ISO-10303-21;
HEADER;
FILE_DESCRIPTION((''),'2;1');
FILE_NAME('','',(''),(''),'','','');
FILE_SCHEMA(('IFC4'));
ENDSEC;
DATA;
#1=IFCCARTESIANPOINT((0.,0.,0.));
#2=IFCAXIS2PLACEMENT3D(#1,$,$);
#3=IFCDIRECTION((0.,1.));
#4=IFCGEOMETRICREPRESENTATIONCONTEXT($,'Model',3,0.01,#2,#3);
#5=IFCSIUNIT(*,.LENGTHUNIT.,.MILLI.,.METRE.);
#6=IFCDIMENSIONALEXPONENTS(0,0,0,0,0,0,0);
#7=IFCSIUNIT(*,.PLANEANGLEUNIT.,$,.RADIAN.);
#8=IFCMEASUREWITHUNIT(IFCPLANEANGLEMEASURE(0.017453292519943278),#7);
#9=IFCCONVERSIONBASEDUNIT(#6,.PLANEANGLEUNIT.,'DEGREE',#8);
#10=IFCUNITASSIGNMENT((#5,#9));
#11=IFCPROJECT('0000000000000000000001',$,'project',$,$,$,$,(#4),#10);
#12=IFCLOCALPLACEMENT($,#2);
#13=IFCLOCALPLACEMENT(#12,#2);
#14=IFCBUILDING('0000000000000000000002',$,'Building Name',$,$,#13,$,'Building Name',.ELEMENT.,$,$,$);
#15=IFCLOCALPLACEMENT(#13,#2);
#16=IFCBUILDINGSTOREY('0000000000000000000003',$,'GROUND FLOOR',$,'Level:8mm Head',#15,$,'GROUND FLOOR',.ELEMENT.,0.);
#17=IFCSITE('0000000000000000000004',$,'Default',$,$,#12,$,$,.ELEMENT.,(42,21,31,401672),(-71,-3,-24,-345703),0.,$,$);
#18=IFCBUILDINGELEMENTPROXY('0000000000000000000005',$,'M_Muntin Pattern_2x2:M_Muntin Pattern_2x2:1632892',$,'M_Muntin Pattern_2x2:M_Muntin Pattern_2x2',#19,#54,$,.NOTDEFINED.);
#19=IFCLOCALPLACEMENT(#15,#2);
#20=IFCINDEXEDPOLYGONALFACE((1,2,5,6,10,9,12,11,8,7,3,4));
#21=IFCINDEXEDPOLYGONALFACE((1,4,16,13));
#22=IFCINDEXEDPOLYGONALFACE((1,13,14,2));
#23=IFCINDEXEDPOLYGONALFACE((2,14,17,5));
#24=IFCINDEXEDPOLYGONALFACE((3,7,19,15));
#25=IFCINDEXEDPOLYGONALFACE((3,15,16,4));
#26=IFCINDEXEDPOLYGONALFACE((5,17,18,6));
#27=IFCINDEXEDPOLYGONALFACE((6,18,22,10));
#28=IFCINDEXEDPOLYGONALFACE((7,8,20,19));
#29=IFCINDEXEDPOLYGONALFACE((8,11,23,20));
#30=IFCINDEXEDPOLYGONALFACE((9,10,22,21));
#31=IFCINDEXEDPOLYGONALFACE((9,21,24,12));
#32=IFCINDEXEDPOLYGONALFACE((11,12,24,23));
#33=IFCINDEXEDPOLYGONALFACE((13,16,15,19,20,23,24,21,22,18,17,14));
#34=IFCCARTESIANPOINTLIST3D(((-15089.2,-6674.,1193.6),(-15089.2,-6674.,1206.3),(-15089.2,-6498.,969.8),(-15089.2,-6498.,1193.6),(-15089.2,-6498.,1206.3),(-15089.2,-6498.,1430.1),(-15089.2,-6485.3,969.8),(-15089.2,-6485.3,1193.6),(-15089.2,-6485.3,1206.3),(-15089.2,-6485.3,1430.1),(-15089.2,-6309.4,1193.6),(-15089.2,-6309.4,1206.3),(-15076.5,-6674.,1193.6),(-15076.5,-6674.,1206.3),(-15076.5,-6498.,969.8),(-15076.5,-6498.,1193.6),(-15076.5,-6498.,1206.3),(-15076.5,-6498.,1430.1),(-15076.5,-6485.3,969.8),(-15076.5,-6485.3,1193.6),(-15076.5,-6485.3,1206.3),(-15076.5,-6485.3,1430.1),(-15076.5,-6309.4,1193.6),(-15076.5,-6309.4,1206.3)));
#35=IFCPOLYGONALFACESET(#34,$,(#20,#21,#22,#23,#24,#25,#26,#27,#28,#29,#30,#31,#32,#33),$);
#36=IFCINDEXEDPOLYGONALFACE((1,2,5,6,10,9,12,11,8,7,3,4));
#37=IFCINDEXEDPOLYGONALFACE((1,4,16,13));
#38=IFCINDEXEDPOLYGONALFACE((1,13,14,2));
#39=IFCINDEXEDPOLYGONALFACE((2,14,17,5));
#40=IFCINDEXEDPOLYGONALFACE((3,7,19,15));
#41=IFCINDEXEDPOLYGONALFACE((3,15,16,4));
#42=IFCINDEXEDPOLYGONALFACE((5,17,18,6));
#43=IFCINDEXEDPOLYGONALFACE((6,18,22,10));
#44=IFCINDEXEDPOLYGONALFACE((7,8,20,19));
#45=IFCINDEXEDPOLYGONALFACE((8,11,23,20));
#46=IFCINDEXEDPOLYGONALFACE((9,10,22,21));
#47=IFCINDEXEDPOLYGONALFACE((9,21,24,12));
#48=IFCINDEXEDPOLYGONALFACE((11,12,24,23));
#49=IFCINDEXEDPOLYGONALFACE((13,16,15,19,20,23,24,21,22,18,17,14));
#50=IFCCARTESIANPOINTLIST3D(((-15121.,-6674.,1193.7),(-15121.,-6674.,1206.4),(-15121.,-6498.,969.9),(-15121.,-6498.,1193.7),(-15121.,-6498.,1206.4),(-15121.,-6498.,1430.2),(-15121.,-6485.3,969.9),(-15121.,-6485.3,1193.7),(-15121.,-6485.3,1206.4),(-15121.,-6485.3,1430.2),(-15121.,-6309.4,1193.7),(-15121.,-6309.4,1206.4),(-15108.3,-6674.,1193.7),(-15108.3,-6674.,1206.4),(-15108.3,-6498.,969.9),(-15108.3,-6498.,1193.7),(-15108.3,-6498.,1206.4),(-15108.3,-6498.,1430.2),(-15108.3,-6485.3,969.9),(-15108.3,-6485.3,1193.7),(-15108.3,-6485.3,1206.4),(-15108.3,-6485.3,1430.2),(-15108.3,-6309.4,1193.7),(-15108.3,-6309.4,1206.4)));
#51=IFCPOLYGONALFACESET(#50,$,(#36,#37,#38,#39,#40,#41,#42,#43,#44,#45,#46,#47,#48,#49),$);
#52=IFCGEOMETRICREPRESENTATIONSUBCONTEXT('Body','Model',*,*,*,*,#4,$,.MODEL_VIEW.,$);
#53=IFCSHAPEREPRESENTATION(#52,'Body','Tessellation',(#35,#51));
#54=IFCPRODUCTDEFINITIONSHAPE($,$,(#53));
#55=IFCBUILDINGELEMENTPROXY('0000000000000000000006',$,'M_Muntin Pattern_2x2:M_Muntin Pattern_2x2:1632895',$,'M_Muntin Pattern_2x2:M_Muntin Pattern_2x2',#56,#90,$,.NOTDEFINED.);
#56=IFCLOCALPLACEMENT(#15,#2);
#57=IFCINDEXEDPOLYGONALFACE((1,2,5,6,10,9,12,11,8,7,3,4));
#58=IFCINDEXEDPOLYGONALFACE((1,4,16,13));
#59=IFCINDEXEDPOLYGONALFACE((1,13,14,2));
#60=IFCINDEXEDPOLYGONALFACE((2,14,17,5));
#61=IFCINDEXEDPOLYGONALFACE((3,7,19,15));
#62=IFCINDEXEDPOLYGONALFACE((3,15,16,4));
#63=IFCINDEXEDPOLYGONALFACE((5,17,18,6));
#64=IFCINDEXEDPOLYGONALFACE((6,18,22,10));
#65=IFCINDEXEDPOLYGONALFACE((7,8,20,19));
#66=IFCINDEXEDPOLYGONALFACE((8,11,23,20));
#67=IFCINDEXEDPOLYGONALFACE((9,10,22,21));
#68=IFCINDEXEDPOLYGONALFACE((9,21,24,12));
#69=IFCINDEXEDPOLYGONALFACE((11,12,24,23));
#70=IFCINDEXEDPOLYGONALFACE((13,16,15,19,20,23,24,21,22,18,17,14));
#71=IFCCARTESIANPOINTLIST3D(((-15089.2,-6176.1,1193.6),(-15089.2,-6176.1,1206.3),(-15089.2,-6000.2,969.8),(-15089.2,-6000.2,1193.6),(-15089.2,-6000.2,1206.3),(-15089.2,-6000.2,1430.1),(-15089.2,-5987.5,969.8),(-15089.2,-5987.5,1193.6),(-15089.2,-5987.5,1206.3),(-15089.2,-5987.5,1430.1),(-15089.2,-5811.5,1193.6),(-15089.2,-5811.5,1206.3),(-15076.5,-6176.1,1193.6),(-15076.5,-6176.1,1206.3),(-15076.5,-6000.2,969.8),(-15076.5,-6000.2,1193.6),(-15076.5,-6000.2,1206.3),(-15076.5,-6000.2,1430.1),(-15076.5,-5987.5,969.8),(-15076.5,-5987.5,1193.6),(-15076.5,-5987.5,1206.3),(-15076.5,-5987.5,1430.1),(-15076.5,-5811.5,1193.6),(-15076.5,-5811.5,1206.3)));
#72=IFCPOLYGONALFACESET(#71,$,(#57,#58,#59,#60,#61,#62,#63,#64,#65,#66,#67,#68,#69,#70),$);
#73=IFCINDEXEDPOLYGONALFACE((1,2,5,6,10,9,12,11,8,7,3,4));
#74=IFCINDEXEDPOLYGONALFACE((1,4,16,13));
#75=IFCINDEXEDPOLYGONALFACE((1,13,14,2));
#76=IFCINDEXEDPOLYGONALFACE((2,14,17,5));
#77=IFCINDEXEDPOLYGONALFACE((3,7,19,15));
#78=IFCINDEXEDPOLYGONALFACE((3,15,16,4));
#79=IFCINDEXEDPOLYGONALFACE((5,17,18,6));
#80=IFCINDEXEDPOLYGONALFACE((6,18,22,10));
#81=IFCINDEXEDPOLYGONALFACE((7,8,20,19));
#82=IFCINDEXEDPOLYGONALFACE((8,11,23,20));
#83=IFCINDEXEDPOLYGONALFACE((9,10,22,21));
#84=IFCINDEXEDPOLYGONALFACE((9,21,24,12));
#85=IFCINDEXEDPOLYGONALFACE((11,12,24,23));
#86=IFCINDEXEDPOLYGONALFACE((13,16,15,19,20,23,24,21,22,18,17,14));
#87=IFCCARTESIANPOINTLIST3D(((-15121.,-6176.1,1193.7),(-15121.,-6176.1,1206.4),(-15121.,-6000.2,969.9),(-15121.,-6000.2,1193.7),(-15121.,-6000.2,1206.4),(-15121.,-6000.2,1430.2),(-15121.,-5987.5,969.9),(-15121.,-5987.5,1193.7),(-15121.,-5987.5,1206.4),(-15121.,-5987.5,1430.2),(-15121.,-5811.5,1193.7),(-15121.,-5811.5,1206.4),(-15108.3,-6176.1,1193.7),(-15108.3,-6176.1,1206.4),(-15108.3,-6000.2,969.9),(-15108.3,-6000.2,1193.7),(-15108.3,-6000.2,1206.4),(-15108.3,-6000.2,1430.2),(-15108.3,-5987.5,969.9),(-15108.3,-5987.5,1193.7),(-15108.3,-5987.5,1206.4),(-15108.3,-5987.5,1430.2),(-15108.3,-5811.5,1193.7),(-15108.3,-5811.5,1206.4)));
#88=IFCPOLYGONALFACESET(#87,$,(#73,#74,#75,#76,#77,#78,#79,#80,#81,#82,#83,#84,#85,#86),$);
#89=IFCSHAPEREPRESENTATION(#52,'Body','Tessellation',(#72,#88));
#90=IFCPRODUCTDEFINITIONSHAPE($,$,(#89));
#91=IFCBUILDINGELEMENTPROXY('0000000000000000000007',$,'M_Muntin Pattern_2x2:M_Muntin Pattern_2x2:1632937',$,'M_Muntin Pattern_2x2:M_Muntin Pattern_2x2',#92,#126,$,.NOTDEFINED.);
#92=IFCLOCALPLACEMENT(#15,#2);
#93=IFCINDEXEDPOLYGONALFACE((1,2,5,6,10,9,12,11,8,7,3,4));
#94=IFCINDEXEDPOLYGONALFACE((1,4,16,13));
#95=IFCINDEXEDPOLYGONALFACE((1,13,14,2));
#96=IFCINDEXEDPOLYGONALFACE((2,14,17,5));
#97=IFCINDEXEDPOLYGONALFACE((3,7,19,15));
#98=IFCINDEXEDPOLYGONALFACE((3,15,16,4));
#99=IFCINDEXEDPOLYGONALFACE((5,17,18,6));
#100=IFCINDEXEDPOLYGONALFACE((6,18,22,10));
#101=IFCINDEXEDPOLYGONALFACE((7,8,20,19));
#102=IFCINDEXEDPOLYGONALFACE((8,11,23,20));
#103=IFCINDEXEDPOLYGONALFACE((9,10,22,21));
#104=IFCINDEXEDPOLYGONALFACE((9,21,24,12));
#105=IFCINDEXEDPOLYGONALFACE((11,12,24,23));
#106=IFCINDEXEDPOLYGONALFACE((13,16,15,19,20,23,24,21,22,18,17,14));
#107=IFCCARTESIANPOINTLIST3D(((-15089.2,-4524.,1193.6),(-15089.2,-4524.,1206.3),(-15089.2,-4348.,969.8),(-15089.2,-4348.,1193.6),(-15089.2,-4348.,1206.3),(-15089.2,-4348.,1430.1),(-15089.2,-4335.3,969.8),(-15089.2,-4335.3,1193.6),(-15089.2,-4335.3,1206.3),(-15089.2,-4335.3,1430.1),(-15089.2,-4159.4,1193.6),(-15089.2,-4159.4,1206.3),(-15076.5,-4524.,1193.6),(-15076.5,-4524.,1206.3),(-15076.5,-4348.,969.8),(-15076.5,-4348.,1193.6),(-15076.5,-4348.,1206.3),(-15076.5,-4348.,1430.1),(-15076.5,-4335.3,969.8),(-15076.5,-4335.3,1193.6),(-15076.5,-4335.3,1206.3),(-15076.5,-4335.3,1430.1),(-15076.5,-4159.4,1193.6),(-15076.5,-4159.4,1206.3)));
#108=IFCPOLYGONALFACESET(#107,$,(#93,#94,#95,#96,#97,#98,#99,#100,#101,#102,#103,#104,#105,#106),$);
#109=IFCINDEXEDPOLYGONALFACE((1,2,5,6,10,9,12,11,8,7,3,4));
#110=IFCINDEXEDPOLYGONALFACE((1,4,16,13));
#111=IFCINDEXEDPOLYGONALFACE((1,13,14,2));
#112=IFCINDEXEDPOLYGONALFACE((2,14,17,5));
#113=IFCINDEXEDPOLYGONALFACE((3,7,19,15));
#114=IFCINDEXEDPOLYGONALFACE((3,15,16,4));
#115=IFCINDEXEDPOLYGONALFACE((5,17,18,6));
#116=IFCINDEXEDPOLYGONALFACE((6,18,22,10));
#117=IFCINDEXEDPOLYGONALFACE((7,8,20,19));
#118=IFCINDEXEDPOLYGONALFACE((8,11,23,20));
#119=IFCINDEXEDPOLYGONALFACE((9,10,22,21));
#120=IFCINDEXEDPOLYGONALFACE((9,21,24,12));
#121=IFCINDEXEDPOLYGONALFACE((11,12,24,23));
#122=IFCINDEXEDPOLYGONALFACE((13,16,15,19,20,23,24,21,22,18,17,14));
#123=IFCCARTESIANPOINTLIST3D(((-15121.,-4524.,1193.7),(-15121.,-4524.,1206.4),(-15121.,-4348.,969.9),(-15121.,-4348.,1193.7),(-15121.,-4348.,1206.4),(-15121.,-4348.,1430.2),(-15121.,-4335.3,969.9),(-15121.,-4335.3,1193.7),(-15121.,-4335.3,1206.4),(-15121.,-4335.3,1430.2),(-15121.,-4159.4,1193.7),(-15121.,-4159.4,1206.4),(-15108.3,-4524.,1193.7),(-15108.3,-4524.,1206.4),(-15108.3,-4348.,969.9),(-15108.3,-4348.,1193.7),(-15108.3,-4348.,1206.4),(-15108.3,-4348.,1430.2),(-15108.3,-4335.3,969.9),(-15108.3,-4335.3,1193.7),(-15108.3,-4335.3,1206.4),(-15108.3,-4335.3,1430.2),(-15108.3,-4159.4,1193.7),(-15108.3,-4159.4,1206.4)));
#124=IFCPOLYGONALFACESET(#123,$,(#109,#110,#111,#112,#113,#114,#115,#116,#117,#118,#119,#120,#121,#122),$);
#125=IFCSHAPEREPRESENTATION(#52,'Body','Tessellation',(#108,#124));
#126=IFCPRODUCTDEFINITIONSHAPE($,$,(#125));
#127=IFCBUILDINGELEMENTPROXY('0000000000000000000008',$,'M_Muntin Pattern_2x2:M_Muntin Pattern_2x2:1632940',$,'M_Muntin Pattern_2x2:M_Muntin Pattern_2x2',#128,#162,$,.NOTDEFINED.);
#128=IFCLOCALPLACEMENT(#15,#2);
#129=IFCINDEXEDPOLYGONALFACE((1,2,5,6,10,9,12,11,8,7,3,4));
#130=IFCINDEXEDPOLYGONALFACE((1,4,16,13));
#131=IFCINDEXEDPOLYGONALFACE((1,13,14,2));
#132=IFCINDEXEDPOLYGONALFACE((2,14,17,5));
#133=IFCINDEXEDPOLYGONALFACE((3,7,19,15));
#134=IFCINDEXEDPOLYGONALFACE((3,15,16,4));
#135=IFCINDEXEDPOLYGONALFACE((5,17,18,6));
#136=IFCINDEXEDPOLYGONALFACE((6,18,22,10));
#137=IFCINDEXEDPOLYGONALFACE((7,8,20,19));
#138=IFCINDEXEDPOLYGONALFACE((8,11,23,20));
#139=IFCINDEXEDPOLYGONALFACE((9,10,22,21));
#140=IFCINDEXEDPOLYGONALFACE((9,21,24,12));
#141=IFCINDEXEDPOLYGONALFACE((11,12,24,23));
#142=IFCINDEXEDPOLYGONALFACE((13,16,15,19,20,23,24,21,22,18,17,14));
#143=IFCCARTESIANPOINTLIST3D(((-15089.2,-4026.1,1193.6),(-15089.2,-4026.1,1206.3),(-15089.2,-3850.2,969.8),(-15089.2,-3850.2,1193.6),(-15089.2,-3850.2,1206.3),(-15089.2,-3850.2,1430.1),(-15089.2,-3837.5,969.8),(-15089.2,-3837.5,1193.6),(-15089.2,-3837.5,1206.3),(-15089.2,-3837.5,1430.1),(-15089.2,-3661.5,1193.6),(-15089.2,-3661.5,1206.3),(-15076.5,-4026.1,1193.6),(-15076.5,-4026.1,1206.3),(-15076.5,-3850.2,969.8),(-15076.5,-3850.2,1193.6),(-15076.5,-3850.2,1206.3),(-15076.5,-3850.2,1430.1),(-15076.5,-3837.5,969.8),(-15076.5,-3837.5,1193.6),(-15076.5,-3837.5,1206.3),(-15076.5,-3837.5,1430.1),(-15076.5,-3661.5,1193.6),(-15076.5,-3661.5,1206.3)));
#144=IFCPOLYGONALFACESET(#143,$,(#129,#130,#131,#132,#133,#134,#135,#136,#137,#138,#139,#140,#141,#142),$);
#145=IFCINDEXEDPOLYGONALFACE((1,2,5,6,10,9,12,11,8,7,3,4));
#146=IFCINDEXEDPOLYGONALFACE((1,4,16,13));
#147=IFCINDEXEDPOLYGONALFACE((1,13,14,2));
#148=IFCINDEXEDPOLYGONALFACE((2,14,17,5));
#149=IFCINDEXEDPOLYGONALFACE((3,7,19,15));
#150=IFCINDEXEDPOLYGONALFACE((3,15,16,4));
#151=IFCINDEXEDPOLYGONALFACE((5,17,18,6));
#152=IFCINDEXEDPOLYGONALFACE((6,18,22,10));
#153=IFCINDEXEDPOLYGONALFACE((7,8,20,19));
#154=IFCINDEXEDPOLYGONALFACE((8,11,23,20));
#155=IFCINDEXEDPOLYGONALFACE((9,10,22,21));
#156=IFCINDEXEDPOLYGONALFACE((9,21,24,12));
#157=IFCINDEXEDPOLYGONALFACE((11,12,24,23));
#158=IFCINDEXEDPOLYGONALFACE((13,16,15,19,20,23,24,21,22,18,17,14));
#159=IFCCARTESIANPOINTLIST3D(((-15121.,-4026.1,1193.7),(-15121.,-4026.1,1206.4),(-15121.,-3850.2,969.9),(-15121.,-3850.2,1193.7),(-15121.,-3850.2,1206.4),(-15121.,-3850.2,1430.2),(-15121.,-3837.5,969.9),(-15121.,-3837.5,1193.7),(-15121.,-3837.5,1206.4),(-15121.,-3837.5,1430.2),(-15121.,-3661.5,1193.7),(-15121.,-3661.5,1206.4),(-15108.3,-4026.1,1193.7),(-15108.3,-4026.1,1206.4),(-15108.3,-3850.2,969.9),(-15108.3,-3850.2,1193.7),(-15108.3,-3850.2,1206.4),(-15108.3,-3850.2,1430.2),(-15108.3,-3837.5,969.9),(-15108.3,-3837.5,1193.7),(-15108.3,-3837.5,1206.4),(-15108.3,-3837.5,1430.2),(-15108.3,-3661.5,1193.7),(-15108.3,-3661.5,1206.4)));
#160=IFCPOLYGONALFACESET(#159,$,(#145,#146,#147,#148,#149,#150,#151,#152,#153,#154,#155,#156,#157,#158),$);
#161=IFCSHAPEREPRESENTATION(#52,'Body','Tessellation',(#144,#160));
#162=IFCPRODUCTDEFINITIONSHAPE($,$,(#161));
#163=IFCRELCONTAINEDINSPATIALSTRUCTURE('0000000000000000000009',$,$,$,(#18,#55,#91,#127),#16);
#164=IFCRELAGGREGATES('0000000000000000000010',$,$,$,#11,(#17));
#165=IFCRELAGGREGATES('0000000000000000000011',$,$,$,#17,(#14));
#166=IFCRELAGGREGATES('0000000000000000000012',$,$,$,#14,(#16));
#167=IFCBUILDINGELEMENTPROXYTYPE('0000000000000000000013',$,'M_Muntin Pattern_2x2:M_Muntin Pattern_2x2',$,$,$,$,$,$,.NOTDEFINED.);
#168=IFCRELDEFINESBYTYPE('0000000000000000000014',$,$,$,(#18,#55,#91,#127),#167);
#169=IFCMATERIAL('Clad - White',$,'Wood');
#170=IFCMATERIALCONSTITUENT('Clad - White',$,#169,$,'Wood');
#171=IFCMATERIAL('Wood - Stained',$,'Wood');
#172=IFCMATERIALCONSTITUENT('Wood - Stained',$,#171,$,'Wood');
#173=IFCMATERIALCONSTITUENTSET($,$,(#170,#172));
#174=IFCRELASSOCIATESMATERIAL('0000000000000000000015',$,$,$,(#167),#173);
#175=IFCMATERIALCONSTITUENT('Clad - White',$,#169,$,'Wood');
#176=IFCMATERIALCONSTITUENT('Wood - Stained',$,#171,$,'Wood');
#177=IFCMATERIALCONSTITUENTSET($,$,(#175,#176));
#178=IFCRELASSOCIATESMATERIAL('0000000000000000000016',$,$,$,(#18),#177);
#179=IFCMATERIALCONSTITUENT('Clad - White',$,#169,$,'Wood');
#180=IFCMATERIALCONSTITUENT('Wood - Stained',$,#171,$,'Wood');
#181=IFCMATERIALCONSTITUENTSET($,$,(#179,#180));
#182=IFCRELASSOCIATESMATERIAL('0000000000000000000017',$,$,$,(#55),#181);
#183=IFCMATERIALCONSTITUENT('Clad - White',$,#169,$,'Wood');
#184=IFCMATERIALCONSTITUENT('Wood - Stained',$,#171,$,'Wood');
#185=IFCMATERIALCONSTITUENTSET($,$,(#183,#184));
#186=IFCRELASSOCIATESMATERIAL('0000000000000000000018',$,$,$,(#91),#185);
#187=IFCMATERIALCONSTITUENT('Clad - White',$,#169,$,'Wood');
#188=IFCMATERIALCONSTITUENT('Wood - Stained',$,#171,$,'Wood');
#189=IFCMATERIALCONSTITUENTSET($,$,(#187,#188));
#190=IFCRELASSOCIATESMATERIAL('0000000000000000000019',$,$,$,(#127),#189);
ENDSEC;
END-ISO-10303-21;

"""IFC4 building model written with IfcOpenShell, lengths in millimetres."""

from ifc_helpers import new_model, entity, si_unit, converted_unit, direction, frame, origin, place, context, subcontext, project, spatial, indexed_curve, outline, extrude, source, transform, mapped, material, constituent, constituent_set, type_object, type_shapes, element, save


model = new_model("IFC4")

# Units and contexts
model_context = context("Model", 3, precision=0.01, world=origin(), true_north=direction((0.0, 1.0)))
body_context = subcontext(model_context, "Body", "Model", "MODEL_VIEW")
ifc_project = project(units=[si_unit("LENGTHUNIT", "METRE", prefix="MILLI"), converted_unit("PLANEANGLEUNIT", "DEGREE", entity("IfcPlaneAngleMeasure", 0.017453292519943278), si_unit("PLANEANGLEUNIT", "RADIAN"), dimensions=[0, 0, 0, 0, 0, 0, 0])], contexts=[model_context])

# Site, building, storey
site_placement = place(None, origin())
site = spatial("IfcSite", under=ifc_project, at=site_placement, Name="Default", CompositionType="ELEMENT", RefLatitude=(42, 21, 31, 401672), RefLongitude=(-71, -3, -24, -345703), RefElevation=0.0)
building_placement = place(site_placement, origin())
building = spatial("IfcBuilding", under=site, at=building_placement, Name="Building Name", LongName="Building Name", CompositionType="ELEMENT")
storey_placement = place(building_placement, origin())
storey = spatial("IfcBuildingStorey", under=building, at=storey_placement, Name="GROUND FLOOR", ObjectType="Level:8mm Head", LongName="GROUND FLOOR", CompositionType="ELEMENT", Elevation=0.0)

# Shared definitions
ifc_material_1 = material(Name="Wood - Stained", Category="Wood")

# Building element proxies
ifc_material_2 = material(Name="Clad - White", Category="Wood")
ifc_constituent_1 = constituent(ifc_material_2, Name="Clad - White", Category="Wood")
ifc_constituent_2 = constituent(ifc_material_1, Name="Wood - Stained", Category="Wood")
ifc_constituent_set_1 = constituent_set(constituents=[ifc_constituent_1, ifc_constituent_2])
ifc_constituent_3 = constituent(ifc_material_2, Name="Clad - White", Category="Wood")
ifc_constituent_4 = constituent(ifc_material_1, Name="Wood - Stained", Category="Wood")
ifc_constituent_set_2 = constituent_set(constituents=[ifc_constituent_3, ifc_constituent_4])
building_element_proxy_type_1 = type_object("IfcBuildingElementProxyType", Name="M_Muntin Pattern_2x2:M_Muntin Pattern_2x2", PredefinedType="NOTDEFINED", material=ifc_constituent_set_2)
shared_shape_1 = source(origin(), body_context, "Body", "SweptSolid", [
    extrude(outline(indexed_curve([(6.4, -6.4), (230.1, -6.4), (230.1, 6.3), (6.4, 6.3), (6.4, 182.3), (-6.3, 182.3), (-6.3, 6.3), (-230.2, 6.3), (-230.2, -6.4), (-6.3, -6.4), (-6.3, -182.3), (6.4, -182.3), (6.4, -6.4)], self_intersect=False)), frame((0.0, -22.2, 230.1), z_axis=(0.0, 1.0, 0.0), x_axis=(0.0, 0.0, 1.0)), (0.0, 0.0, 1.0), 12.7),
    extrude(outline(indexed_curve([(6.4, -6.4), (230.2, -6.4), (230.2, 6.3), (6.4, 6.3), (6.4, 182.3), (-6.3, 182.3), (-6.3, 6.3), (-230.2, 6.3), (-230.2, -6.4), (-6.3, -6.4), (-6.3, -182.3), (6.4, -182.3), (6.4, -6.4)], self_intersect=False)), frame((0.0, 9.5, 230.2), z_axis=(0.0, 1.0, 0.0), x_axis=(0.0, 0.0, 1.0)), (0.0, 0.0, 1.0), 12.7),
])
type_shapes(building_element_proxy_type_1, [shared_shape_1])
proxy_1_placement = place(storey_placement, frame((-15098.7, -6491.7, 969.9), z_axis=(0.0, 0.0, 1.0), x_axis=(0.0, 1.0, 0.0)))
element("IfcBuildingElementProxy", 1, at=proxy_1_placement, inside=storey, type_object=building_element_proxy_type_1, material=ifc_constituent_set_1, Name="M_Muntin Pattern_2x2:M_Muntin Pattern_2x2:1632892", ObjectType="M_Muntin Pattern_2x2:M_Muntin Pattern_2x2", PredefinedType="NOTDEFINED", context=body_context, shape_type="MappedRepresentation", body=[
    mapped(shared_shape_1, transform((0.0, 0.0, 0.0), scale=1.0)),
])
ifc_constituent_5 = constituent(ifc_material_2, Name="Clad - White", Category="Wood")
ifc_constituent_6 = constituent(ifc_material_1, Name="Wood - Stained", Category="Wood")
ifc_constituent_set_3 = constituent_set(constituents=[ifc_constituent_5, ifc_constituent_6])
proxy_2_placement = place(storey_placement, frame((-15098.7, -5993.8, 969.9), z_axis=(0.0, 0.0, 1.0), x_axis=(0.0, 1.0, 0.0)))
element("IfcBuildingElementProxy", 2, at=proxy_2_placement, inside=storey, type_object=building_element_proxy_type_1, material=ifc_constituent_set_3, Name="M_Muntin Pattern_2x2:M_Muntin Pattern_2x2:1632895", ObjectType="M_Muntin Pattern_2x2:M_Muntin Pattern_2x2", PredefinedType="NOTDEFINED", context=body_context, shape_type="MappedRepresentation", body=[
    mapped(shared_shape_1, transform((0.0, 0.0, 0.0), scale=1.0)),
])
ifc_constituent_7 = constituent(ifc_material_2, Name="Clad - White", Category="Wood")
ifc_constituent_8 = constituent(ifc_material_1, Name="Wood - Stained", Category="Wood")
ifc_constituent_set_4 = constituent_set(constituents=[ifc_constituent_7, ifc_constituent_8])
proxy_3_placement = place(storey_placement, frame((-15098.7, -4341.7, 969.9), z_axis=(0.0, 0.0, 1.0), x_axis=(0.0, 1.0, 0.0)))
element("IfcBuildingElementProxy", 3, at=proxy_3_placement, inside=storey, type_object=building_element_proxy_type_1, material=ifc_constituent_set_4, Name="M_Muntin Pattern_2x2:M_Muntin Pattern_2x2:1632937", ObjectType="M_Muntin Pattern_2x2:M_Muntin Pattern_2x2", PredefinedType="NOTDEFINED", context=body_context, shape_type="MappedRepresentation", body=[
    mapped(shared_shape_1, transform((0.0, 0.0, 0.0), scale=1.0)),
])
ifc_constituent_9 = constituent(ifc_material_2, Name="Clad - White", Category="Wood")
ifc_constituent_10 = constituent(ifc_material_1, Name="Wood - Stained", Category="Wood")
ifc_constituent_set_5 = constituent_set(constituents=[ifc_constituent_9, ifc_constituent_10])
proxy_4_placement = place(storey_placement, frame((-15098.7, -3843.8, 969.9), z_axis=(0.0, 0.0, 1.0), x_axis=(0.0, 1.0, 0.0)))
element("IfcBuildingElementProxy", 4, at=proxy_4_placement, inside=storey, type_object=building_element_proxy_type_1, material=ifc_constituent_set_5, Name="M_Muntin Pattern_2x2:M_Muntin Pattern_2x2:1632940", ObjectType="M_Muntin Pattern_2x2:M_Muntin Pattern_2x2", PredefinedType="NOTDEFINED", context=body_context, shape_type="MappedRepresentation", body=[
    mapped(shared_shape_1, transform((0.0, 0.0, 0.0), scale=1.0)),
])

save(model, "model.ifc")
